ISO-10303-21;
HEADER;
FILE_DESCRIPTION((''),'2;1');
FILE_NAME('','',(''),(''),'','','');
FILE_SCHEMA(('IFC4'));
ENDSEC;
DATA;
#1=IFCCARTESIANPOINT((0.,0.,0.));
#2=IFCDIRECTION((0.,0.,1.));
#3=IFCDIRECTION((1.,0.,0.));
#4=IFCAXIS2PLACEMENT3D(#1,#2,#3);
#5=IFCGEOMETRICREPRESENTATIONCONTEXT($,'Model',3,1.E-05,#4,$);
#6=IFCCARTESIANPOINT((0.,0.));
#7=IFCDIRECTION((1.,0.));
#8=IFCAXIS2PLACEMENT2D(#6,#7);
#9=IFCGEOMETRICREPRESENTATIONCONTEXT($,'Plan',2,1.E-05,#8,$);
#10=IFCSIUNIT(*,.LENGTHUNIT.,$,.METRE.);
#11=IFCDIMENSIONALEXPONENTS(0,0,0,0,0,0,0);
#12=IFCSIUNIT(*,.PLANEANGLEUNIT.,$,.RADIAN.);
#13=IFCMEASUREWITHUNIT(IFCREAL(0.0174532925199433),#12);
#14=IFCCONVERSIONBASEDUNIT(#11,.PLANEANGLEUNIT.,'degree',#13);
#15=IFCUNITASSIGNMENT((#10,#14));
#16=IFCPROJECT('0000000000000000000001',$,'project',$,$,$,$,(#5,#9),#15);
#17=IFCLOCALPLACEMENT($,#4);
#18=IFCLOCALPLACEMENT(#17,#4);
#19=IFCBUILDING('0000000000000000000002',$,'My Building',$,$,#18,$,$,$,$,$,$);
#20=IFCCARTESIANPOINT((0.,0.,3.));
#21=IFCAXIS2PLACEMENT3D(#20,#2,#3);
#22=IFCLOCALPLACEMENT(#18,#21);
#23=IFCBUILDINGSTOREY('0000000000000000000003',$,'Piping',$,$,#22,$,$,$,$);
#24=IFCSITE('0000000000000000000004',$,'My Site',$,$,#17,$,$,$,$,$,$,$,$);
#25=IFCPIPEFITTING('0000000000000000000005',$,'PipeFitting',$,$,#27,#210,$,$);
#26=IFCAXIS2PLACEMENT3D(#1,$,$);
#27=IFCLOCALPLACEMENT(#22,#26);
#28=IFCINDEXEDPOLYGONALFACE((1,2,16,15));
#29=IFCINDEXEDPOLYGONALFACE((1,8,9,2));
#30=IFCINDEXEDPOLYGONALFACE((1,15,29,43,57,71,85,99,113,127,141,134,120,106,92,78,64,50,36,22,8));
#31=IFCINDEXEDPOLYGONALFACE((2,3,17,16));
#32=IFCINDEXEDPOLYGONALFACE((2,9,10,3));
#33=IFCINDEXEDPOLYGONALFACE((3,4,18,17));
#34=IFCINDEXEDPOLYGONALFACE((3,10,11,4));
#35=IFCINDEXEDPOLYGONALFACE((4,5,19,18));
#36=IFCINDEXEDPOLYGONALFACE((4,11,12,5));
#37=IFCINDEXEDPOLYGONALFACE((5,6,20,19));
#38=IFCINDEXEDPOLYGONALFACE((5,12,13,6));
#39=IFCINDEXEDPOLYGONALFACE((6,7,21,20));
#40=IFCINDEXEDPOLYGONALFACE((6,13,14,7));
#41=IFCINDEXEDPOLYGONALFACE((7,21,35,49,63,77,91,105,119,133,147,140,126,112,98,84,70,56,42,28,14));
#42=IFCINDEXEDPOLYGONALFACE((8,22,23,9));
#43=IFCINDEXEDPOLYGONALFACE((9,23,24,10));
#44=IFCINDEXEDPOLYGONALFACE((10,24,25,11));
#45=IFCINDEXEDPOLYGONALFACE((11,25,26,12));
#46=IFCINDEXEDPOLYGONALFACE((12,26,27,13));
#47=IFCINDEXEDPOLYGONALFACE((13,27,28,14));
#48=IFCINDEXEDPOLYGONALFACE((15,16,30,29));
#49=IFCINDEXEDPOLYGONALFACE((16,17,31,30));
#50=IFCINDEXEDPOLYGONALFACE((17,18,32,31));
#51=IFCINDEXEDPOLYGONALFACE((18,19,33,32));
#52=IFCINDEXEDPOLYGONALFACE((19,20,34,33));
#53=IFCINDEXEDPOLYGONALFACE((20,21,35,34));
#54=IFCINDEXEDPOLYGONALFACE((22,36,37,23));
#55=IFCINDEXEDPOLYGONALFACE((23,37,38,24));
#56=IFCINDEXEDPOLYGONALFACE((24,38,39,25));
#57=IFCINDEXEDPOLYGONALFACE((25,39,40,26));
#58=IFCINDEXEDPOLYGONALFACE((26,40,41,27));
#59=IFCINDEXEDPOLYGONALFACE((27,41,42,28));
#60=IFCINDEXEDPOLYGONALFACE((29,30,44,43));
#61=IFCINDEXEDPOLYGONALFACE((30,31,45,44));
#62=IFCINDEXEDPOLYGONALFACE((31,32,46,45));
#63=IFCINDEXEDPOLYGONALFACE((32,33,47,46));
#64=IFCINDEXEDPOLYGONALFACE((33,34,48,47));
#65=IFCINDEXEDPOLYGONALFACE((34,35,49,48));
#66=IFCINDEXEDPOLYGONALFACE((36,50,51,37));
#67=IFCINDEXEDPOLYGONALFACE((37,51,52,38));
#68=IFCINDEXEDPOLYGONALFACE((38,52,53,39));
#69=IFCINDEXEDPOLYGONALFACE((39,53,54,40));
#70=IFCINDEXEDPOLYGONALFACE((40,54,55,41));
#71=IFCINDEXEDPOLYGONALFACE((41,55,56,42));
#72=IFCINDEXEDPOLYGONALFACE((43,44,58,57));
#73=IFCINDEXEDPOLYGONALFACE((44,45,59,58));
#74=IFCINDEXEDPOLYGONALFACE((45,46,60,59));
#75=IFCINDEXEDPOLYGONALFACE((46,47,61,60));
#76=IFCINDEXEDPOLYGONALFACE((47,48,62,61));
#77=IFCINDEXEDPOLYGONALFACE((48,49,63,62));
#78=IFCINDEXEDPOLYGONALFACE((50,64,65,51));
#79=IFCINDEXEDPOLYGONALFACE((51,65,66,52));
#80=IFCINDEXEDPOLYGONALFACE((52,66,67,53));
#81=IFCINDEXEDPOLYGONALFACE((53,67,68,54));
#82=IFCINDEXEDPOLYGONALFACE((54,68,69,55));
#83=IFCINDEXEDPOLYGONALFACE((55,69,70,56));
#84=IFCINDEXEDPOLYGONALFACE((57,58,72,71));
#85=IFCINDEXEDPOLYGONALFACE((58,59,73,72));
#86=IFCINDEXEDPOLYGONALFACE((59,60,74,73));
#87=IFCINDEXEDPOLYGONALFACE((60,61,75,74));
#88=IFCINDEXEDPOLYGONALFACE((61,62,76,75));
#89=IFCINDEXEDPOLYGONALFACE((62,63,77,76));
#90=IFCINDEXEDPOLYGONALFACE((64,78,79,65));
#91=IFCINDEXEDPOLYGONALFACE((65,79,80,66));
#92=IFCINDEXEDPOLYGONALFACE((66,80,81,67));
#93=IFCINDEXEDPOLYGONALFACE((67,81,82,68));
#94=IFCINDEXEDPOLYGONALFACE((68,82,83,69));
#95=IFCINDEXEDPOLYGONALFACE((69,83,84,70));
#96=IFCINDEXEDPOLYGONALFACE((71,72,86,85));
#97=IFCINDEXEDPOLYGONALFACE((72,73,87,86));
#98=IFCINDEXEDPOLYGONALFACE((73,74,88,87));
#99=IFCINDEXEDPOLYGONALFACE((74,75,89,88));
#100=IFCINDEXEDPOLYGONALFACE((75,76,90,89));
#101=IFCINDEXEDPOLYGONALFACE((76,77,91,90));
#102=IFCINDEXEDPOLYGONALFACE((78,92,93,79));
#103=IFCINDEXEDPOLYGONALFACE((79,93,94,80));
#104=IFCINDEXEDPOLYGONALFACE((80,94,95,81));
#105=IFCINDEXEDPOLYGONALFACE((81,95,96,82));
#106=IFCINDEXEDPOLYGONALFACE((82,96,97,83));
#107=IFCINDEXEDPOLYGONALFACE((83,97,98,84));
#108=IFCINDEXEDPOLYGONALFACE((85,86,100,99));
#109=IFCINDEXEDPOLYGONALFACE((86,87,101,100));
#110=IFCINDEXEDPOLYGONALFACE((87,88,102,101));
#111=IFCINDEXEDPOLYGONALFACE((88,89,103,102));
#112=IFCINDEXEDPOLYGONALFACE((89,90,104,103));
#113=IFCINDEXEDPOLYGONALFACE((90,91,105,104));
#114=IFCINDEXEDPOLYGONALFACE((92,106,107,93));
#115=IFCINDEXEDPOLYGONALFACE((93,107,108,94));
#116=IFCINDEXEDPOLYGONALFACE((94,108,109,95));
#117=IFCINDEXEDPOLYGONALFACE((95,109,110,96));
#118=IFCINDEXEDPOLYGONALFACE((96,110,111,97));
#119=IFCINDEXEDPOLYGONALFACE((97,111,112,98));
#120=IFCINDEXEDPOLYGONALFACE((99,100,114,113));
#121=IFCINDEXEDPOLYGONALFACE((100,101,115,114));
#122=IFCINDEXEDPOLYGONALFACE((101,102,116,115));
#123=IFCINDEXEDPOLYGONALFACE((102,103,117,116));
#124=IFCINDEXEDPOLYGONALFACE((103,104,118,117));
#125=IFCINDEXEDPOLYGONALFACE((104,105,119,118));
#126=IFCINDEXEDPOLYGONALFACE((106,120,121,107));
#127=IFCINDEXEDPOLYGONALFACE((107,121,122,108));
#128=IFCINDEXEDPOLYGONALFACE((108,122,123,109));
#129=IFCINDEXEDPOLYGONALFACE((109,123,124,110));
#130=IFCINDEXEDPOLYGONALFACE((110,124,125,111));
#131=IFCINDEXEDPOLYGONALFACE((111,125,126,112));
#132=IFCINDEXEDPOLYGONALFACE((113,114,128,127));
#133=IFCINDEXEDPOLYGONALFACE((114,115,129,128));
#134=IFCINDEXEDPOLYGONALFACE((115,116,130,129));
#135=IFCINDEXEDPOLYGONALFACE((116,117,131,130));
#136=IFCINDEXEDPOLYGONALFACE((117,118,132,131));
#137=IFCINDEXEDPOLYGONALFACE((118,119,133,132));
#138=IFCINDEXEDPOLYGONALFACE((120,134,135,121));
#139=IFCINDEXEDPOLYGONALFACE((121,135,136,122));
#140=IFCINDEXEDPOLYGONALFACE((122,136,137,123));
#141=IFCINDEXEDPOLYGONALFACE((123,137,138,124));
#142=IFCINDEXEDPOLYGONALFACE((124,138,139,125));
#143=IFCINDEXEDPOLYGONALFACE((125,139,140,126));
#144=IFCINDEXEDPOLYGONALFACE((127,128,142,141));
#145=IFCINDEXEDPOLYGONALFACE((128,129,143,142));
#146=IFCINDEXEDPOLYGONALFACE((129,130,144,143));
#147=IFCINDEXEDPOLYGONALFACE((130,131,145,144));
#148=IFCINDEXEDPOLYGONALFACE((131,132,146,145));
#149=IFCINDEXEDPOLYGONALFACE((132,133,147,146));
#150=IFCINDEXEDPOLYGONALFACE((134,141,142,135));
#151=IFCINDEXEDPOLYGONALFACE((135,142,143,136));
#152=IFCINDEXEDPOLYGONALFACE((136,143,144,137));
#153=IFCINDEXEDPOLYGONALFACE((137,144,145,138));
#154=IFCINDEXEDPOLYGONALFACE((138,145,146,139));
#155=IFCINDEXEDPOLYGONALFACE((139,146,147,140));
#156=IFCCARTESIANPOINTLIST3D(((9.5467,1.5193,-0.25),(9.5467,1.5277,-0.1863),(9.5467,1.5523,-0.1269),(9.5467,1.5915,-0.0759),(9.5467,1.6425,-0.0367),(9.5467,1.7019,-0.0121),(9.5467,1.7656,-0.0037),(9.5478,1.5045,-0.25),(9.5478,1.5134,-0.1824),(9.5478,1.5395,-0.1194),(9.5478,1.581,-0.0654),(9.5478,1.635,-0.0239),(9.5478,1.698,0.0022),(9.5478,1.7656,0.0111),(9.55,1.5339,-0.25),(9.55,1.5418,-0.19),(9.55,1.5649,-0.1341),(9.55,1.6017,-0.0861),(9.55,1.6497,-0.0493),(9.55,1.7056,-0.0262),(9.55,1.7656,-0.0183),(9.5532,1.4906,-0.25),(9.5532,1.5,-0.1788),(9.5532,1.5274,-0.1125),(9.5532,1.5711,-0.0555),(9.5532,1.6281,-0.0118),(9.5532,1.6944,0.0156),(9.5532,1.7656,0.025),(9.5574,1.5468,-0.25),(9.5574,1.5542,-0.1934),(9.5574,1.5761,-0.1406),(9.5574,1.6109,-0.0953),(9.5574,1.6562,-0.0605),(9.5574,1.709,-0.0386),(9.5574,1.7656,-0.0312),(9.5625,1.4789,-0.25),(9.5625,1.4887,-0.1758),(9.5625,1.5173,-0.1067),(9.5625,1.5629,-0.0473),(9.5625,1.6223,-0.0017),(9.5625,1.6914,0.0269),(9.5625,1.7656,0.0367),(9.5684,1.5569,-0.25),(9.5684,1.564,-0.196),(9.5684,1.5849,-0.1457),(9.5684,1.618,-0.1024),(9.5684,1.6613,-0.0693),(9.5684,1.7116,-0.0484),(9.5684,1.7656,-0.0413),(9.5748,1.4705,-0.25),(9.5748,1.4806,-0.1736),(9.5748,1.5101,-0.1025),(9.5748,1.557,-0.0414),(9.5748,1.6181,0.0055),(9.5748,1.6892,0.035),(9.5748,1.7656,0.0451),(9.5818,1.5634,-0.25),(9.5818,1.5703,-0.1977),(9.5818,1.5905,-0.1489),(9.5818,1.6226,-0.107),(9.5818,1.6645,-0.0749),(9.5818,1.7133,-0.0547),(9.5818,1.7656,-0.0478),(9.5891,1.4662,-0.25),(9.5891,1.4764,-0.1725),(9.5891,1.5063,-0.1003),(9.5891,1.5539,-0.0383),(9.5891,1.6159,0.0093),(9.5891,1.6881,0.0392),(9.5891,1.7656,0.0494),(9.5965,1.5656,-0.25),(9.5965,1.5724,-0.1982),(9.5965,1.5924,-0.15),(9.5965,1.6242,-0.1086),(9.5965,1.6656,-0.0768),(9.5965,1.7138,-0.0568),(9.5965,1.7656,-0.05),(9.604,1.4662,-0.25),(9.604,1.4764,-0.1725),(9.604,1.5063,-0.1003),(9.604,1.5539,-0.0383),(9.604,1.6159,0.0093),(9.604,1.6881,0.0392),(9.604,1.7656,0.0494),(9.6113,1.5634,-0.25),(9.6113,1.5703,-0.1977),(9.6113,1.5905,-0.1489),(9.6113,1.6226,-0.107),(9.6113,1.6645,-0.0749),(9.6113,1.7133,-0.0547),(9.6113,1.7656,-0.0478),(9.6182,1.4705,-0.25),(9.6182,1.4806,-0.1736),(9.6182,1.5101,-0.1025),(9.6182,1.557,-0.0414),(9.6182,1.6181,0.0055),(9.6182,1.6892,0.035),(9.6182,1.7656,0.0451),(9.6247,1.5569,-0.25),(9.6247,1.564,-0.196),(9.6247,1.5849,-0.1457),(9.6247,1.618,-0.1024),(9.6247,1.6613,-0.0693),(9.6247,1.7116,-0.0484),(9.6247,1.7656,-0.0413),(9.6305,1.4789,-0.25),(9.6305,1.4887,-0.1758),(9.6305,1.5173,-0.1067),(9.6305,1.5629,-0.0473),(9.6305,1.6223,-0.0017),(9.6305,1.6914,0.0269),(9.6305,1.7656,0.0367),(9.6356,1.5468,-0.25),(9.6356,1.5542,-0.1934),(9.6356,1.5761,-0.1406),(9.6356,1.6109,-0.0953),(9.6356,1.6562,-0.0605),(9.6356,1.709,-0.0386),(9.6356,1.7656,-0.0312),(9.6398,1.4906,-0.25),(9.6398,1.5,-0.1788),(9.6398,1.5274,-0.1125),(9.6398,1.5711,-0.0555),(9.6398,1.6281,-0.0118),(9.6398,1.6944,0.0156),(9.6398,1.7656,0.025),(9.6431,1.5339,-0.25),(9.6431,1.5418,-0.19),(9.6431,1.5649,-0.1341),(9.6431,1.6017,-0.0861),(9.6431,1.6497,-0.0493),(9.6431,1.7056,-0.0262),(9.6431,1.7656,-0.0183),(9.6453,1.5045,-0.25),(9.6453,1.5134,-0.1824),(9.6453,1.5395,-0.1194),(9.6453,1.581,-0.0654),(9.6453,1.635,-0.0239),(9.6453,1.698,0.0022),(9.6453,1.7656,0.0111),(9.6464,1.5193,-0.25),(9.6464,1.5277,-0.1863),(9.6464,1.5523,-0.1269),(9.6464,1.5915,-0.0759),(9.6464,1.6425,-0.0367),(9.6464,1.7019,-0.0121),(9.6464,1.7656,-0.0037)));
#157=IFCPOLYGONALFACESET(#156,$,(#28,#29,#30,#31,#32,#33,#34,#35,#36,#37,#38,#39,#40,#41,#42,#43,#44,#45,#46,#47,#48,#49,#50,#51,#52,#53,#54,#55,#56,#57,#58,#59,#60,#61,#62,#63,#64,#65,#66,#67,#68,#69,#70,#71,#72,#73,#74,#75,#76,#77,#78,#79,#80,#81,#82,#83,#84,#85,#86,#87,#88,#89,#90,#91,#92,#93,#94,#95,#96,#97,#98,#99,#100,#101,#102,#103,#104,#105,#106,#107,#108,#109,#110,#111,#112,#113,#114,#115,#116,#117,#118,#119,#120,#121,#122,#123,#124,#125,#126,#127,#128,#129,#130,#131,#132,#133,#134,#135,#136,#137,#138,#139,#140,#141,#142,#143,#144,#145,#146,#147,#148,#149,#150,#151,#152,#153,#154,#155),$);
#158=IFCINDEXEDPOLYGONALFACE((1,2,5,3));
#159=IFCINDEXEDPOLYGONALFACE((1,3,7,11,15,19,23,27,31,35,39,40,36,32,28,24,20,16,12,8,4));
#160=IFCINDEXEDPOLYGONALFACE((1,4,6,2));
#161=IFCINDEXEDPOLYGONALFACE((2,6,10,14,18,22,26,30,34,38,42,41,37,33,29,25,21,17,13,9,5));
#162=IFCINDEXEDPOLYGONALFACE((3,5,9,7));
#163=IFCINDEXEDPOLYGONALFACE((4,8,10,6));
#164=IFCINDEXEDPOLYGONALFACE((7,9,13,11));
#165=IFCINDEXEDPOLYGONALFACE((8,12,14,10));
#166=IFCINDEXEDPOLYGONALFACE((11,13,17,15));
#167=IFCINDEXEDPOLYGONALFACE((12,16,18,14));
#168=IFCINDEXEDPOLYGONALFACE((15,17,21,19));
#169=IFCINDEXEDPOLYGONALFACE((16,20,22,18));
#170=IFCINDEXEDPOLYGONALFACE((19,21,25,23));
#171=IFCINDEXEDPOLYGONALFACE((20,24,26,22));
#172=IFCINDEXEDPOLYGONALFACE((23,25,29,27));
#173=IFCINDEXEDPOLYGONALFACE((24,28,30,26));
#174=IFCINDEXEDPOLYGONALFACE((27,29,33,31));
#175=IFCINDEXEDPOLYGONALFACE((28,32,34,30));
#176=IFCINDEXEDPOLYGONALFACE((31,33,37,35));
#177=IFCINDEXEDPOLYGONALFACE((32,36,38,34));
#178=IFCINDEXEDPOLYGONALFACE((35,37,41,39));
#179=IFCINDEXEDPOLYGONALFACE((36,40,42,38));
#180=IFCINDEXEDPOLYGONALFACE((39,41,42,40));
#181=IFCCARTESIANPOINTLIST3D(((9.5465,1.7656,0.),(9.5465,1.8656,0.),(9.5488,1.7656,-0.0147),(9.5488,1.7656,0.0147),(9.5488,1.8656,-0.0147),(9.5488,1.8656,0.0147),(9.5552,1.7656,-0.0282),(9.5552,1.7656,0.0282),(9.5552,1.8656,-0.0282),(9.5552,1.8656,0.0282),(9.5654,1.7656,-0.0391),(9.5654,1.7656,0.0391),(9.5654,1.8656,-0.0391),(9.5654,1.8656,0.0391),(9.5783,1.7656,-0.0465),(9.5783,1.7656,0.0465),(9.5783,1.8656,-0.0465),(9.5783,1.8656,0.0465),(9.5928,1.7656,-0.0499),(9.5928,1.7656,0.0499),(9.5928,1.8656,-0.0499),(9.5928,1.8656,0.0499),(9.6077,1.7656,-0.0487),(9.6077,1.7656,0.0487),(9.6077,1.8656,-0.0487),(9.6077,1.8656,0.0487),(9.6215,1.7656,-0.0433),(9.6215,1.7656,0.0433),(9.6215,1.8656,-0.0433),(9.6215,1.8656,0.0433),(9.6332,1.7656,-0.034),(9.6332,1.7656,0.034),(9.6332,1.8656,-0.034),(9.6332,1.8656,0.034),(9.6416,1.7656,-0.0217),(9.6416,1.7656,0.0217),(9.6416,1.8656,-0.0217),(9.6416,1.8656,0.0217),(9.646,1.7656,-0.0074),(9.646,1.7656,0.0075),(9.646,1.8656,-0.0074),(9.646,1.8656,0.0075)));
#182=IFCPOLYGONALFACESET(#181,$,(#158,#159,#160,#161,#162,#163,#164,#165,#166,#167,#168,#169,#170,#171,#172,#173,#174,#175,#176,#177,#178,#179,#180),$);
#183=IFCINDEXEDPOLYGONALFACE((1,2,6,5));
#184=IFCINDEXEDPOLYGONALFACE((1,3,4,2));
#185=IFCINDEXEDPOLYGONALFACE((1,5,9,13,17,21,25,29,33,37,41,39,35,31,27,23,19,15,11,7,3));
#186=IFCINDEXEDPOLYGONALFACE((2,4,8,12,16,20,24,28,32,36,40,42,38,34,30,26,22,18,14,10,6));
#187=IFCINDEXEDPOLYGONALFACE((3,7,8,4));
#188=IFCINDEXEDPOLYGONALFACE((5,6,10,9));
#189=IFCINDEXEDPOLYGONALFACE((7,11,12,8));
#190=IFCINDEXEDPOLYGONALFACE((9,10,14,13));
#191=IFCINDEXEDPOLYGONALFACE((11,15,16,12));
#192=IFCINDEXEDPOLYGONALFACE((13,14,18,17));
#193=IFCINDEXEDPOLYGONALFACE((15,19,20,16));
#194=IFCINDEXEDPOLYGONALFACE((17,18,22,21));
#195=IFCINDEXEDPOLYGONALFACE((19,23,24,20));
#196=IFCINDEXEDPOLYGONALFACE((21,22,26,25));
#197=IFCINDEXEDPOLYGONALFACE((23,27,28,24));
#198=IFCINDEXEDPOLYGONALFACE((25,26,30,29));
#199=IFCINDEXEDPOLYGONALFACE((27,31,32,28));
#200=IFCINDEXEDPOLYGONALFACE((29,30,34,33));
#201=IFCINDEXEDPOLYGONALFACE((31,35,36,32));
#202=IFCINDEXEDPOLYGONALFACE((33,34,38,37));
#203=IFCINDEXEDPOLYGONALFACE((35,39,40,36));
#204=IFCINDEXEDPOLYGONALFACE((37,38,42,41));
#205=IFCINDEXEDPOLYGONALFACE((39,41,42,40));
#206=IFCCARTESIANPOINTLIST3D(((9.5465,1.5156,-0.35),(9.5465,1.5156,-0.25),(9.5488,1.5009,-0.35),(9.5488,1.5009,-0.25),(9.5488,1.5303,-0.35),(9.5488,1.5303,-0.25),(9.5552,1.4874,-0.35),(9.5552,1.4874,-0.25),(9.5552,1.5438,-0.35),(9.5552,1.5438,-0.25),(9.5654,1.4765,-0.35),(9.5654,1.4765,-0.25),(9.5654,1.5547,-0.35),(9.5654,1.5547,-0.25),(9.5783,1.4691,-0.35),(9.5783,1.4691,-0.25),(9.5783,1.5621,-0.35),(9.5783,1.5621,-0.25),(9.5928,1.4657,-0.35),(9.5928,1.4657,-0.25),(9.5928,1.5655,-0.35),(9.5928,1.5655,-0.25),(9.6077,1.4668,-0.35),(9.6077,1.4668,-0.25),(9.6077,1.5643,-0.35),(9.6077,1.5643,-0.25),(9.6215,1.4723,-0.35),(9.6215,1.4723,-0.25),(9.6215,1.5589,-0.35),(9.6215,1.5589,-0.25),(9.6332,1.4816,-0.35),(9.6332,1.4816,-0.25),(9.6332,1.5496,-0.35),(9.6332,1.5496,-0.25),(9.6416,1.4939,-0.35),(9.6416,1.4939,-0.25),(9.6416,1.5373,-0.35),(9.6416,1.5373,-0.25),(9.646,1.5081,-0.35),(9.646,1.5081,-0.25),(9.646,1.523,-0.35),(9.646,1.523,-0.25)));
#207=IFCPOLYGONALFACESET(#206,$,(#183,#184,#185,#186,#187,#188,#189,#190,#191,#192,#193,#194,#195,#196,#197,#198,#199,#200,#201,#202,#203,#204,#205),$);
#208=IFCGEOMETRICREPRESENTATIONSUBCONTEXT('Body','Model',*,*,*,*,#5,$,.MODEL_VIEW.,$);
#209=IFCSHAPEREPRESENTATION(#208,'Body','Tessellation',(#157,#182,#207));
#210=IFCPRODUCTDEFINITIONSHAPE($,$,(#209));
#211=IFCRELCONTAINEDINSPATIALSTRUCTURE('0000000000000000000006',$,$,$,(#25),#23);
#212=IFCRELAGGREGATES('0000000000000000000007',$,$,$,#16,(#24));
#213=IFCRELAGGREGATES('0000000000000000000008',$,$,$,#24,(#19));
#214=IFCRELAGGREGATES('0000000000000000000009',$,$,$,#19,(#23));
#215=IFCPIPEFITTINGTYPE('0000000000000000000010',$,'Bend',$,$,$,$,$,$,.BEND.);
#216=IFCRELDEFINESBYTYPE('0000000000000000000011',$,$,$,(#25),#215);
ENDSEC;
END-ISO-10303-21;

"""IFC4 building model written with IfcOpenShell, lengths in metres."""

from ifc_helpers import new_model, entity, si_unit, converted_unit, frame, origin_with_axes, origin_2d_with_axis, place, context, subcontext, project, spatial, circle, extrude, source, transform, mapped, type_object, type_shapes, element, save


model = new_model("IFC4")

# Units and contexts
model_context = context("Model", 3, precision=1e-05, world=origin_with_axes())
plan_context = context("Plan", 2, precision=1e-05, world=origin_2d_with_axis())
body_context = subcontext(model_context, "Body", "Model", "MODEL_VIEW")
ifc_project = project(units=[si_unit("LENGTHUNIT", "METRE"), converted_unit("PLANEANGLEUNIT", "degree", entity("IfcReal", 0.0174532925199433), si_unit("PLANEANGLEUNIT", "RADIAN"), dimensions=[0, 0, 0, 0, 0, 0, 0])], contexts=[model_context, plan_context])

# Site, building, storey
site_placement = place(None, origin_with_axes())
site = spatial("IfcSite", under=ifc_project, at=site_placement, Name="My Site")
building_placement = place(site_placement, origin_with_axes())
building = spatial("IfcBuilding", under=site, at=building_placement, Name="My Building")
storey_placement = place(building_placement, frame((0.0, 0.0, 3.0), z_axis=(0.0, 0.0, 1.0), x_axis=(1.0, 0.0, 0.0)))
storey = spatial("IfcBuildingStorey", under=building, at=storey_placement, Name="Piping")

# Shared definitions
pipe_fitting_type = type_object("IfcPipeFittingType", Name="Bend", PredefinedType="BEND")
shared_shape = source(origin_with_axes(), body_context, "Body", "SolidModel", [
    entity("IfcSweptDiskSolid", entity("IfcIndexedPolyCurve", entity("IfcCartesianPointList3D", [[0.0, 0.0, -0.1], [0.0, -0.0732, -0.2768], [0.0, -0.25, -0.35]]), [entity("IfcArcIndex", [1, 2, 3])]), 0.05),
    extrude(circle(Radius=0.05), origin_with_axes(), (0.0, 0.0, -1.0), 0.1),
    extrude(circle(Radius=0.05), frame((0.0, -0.25, -0.35), z_axis=(0.0, -1.0, 0.0), x_axis=(1.0, 0.0, 0.0)), (0.0, 0.0, 1.0), 0.1),
])
type_shapes(pipe_fitting_type, [shared_shape])

# Pipe fitting
for number, where, z_axis, x_axis, name in (
    (1, (9.5965, 1.8656, 0.0), (0.0, 1.0, 0.0), (-1.0, 0.0, 0.0), "PipeFitting"),
):
    element("IfcPipeFitting", number, at=place(storey_placement, frame(where, z_axis=z_axis, x_axis=x_axis)), inside=storey, type_object=pipe_fitting_type, Name=name, context=body_context, shape_type="MappedRepresentation", body=[
        mapped(shared_shape, transform((0.0, 0.0, 0.0), x_axis=(1.0, 0.0, 0.0), y_axis=(0.0, 1.0, 0.0), z_axis=(0.0, 0.0, 1.0), scale=1.0)),
    ])

save(model, "model.ifc")
